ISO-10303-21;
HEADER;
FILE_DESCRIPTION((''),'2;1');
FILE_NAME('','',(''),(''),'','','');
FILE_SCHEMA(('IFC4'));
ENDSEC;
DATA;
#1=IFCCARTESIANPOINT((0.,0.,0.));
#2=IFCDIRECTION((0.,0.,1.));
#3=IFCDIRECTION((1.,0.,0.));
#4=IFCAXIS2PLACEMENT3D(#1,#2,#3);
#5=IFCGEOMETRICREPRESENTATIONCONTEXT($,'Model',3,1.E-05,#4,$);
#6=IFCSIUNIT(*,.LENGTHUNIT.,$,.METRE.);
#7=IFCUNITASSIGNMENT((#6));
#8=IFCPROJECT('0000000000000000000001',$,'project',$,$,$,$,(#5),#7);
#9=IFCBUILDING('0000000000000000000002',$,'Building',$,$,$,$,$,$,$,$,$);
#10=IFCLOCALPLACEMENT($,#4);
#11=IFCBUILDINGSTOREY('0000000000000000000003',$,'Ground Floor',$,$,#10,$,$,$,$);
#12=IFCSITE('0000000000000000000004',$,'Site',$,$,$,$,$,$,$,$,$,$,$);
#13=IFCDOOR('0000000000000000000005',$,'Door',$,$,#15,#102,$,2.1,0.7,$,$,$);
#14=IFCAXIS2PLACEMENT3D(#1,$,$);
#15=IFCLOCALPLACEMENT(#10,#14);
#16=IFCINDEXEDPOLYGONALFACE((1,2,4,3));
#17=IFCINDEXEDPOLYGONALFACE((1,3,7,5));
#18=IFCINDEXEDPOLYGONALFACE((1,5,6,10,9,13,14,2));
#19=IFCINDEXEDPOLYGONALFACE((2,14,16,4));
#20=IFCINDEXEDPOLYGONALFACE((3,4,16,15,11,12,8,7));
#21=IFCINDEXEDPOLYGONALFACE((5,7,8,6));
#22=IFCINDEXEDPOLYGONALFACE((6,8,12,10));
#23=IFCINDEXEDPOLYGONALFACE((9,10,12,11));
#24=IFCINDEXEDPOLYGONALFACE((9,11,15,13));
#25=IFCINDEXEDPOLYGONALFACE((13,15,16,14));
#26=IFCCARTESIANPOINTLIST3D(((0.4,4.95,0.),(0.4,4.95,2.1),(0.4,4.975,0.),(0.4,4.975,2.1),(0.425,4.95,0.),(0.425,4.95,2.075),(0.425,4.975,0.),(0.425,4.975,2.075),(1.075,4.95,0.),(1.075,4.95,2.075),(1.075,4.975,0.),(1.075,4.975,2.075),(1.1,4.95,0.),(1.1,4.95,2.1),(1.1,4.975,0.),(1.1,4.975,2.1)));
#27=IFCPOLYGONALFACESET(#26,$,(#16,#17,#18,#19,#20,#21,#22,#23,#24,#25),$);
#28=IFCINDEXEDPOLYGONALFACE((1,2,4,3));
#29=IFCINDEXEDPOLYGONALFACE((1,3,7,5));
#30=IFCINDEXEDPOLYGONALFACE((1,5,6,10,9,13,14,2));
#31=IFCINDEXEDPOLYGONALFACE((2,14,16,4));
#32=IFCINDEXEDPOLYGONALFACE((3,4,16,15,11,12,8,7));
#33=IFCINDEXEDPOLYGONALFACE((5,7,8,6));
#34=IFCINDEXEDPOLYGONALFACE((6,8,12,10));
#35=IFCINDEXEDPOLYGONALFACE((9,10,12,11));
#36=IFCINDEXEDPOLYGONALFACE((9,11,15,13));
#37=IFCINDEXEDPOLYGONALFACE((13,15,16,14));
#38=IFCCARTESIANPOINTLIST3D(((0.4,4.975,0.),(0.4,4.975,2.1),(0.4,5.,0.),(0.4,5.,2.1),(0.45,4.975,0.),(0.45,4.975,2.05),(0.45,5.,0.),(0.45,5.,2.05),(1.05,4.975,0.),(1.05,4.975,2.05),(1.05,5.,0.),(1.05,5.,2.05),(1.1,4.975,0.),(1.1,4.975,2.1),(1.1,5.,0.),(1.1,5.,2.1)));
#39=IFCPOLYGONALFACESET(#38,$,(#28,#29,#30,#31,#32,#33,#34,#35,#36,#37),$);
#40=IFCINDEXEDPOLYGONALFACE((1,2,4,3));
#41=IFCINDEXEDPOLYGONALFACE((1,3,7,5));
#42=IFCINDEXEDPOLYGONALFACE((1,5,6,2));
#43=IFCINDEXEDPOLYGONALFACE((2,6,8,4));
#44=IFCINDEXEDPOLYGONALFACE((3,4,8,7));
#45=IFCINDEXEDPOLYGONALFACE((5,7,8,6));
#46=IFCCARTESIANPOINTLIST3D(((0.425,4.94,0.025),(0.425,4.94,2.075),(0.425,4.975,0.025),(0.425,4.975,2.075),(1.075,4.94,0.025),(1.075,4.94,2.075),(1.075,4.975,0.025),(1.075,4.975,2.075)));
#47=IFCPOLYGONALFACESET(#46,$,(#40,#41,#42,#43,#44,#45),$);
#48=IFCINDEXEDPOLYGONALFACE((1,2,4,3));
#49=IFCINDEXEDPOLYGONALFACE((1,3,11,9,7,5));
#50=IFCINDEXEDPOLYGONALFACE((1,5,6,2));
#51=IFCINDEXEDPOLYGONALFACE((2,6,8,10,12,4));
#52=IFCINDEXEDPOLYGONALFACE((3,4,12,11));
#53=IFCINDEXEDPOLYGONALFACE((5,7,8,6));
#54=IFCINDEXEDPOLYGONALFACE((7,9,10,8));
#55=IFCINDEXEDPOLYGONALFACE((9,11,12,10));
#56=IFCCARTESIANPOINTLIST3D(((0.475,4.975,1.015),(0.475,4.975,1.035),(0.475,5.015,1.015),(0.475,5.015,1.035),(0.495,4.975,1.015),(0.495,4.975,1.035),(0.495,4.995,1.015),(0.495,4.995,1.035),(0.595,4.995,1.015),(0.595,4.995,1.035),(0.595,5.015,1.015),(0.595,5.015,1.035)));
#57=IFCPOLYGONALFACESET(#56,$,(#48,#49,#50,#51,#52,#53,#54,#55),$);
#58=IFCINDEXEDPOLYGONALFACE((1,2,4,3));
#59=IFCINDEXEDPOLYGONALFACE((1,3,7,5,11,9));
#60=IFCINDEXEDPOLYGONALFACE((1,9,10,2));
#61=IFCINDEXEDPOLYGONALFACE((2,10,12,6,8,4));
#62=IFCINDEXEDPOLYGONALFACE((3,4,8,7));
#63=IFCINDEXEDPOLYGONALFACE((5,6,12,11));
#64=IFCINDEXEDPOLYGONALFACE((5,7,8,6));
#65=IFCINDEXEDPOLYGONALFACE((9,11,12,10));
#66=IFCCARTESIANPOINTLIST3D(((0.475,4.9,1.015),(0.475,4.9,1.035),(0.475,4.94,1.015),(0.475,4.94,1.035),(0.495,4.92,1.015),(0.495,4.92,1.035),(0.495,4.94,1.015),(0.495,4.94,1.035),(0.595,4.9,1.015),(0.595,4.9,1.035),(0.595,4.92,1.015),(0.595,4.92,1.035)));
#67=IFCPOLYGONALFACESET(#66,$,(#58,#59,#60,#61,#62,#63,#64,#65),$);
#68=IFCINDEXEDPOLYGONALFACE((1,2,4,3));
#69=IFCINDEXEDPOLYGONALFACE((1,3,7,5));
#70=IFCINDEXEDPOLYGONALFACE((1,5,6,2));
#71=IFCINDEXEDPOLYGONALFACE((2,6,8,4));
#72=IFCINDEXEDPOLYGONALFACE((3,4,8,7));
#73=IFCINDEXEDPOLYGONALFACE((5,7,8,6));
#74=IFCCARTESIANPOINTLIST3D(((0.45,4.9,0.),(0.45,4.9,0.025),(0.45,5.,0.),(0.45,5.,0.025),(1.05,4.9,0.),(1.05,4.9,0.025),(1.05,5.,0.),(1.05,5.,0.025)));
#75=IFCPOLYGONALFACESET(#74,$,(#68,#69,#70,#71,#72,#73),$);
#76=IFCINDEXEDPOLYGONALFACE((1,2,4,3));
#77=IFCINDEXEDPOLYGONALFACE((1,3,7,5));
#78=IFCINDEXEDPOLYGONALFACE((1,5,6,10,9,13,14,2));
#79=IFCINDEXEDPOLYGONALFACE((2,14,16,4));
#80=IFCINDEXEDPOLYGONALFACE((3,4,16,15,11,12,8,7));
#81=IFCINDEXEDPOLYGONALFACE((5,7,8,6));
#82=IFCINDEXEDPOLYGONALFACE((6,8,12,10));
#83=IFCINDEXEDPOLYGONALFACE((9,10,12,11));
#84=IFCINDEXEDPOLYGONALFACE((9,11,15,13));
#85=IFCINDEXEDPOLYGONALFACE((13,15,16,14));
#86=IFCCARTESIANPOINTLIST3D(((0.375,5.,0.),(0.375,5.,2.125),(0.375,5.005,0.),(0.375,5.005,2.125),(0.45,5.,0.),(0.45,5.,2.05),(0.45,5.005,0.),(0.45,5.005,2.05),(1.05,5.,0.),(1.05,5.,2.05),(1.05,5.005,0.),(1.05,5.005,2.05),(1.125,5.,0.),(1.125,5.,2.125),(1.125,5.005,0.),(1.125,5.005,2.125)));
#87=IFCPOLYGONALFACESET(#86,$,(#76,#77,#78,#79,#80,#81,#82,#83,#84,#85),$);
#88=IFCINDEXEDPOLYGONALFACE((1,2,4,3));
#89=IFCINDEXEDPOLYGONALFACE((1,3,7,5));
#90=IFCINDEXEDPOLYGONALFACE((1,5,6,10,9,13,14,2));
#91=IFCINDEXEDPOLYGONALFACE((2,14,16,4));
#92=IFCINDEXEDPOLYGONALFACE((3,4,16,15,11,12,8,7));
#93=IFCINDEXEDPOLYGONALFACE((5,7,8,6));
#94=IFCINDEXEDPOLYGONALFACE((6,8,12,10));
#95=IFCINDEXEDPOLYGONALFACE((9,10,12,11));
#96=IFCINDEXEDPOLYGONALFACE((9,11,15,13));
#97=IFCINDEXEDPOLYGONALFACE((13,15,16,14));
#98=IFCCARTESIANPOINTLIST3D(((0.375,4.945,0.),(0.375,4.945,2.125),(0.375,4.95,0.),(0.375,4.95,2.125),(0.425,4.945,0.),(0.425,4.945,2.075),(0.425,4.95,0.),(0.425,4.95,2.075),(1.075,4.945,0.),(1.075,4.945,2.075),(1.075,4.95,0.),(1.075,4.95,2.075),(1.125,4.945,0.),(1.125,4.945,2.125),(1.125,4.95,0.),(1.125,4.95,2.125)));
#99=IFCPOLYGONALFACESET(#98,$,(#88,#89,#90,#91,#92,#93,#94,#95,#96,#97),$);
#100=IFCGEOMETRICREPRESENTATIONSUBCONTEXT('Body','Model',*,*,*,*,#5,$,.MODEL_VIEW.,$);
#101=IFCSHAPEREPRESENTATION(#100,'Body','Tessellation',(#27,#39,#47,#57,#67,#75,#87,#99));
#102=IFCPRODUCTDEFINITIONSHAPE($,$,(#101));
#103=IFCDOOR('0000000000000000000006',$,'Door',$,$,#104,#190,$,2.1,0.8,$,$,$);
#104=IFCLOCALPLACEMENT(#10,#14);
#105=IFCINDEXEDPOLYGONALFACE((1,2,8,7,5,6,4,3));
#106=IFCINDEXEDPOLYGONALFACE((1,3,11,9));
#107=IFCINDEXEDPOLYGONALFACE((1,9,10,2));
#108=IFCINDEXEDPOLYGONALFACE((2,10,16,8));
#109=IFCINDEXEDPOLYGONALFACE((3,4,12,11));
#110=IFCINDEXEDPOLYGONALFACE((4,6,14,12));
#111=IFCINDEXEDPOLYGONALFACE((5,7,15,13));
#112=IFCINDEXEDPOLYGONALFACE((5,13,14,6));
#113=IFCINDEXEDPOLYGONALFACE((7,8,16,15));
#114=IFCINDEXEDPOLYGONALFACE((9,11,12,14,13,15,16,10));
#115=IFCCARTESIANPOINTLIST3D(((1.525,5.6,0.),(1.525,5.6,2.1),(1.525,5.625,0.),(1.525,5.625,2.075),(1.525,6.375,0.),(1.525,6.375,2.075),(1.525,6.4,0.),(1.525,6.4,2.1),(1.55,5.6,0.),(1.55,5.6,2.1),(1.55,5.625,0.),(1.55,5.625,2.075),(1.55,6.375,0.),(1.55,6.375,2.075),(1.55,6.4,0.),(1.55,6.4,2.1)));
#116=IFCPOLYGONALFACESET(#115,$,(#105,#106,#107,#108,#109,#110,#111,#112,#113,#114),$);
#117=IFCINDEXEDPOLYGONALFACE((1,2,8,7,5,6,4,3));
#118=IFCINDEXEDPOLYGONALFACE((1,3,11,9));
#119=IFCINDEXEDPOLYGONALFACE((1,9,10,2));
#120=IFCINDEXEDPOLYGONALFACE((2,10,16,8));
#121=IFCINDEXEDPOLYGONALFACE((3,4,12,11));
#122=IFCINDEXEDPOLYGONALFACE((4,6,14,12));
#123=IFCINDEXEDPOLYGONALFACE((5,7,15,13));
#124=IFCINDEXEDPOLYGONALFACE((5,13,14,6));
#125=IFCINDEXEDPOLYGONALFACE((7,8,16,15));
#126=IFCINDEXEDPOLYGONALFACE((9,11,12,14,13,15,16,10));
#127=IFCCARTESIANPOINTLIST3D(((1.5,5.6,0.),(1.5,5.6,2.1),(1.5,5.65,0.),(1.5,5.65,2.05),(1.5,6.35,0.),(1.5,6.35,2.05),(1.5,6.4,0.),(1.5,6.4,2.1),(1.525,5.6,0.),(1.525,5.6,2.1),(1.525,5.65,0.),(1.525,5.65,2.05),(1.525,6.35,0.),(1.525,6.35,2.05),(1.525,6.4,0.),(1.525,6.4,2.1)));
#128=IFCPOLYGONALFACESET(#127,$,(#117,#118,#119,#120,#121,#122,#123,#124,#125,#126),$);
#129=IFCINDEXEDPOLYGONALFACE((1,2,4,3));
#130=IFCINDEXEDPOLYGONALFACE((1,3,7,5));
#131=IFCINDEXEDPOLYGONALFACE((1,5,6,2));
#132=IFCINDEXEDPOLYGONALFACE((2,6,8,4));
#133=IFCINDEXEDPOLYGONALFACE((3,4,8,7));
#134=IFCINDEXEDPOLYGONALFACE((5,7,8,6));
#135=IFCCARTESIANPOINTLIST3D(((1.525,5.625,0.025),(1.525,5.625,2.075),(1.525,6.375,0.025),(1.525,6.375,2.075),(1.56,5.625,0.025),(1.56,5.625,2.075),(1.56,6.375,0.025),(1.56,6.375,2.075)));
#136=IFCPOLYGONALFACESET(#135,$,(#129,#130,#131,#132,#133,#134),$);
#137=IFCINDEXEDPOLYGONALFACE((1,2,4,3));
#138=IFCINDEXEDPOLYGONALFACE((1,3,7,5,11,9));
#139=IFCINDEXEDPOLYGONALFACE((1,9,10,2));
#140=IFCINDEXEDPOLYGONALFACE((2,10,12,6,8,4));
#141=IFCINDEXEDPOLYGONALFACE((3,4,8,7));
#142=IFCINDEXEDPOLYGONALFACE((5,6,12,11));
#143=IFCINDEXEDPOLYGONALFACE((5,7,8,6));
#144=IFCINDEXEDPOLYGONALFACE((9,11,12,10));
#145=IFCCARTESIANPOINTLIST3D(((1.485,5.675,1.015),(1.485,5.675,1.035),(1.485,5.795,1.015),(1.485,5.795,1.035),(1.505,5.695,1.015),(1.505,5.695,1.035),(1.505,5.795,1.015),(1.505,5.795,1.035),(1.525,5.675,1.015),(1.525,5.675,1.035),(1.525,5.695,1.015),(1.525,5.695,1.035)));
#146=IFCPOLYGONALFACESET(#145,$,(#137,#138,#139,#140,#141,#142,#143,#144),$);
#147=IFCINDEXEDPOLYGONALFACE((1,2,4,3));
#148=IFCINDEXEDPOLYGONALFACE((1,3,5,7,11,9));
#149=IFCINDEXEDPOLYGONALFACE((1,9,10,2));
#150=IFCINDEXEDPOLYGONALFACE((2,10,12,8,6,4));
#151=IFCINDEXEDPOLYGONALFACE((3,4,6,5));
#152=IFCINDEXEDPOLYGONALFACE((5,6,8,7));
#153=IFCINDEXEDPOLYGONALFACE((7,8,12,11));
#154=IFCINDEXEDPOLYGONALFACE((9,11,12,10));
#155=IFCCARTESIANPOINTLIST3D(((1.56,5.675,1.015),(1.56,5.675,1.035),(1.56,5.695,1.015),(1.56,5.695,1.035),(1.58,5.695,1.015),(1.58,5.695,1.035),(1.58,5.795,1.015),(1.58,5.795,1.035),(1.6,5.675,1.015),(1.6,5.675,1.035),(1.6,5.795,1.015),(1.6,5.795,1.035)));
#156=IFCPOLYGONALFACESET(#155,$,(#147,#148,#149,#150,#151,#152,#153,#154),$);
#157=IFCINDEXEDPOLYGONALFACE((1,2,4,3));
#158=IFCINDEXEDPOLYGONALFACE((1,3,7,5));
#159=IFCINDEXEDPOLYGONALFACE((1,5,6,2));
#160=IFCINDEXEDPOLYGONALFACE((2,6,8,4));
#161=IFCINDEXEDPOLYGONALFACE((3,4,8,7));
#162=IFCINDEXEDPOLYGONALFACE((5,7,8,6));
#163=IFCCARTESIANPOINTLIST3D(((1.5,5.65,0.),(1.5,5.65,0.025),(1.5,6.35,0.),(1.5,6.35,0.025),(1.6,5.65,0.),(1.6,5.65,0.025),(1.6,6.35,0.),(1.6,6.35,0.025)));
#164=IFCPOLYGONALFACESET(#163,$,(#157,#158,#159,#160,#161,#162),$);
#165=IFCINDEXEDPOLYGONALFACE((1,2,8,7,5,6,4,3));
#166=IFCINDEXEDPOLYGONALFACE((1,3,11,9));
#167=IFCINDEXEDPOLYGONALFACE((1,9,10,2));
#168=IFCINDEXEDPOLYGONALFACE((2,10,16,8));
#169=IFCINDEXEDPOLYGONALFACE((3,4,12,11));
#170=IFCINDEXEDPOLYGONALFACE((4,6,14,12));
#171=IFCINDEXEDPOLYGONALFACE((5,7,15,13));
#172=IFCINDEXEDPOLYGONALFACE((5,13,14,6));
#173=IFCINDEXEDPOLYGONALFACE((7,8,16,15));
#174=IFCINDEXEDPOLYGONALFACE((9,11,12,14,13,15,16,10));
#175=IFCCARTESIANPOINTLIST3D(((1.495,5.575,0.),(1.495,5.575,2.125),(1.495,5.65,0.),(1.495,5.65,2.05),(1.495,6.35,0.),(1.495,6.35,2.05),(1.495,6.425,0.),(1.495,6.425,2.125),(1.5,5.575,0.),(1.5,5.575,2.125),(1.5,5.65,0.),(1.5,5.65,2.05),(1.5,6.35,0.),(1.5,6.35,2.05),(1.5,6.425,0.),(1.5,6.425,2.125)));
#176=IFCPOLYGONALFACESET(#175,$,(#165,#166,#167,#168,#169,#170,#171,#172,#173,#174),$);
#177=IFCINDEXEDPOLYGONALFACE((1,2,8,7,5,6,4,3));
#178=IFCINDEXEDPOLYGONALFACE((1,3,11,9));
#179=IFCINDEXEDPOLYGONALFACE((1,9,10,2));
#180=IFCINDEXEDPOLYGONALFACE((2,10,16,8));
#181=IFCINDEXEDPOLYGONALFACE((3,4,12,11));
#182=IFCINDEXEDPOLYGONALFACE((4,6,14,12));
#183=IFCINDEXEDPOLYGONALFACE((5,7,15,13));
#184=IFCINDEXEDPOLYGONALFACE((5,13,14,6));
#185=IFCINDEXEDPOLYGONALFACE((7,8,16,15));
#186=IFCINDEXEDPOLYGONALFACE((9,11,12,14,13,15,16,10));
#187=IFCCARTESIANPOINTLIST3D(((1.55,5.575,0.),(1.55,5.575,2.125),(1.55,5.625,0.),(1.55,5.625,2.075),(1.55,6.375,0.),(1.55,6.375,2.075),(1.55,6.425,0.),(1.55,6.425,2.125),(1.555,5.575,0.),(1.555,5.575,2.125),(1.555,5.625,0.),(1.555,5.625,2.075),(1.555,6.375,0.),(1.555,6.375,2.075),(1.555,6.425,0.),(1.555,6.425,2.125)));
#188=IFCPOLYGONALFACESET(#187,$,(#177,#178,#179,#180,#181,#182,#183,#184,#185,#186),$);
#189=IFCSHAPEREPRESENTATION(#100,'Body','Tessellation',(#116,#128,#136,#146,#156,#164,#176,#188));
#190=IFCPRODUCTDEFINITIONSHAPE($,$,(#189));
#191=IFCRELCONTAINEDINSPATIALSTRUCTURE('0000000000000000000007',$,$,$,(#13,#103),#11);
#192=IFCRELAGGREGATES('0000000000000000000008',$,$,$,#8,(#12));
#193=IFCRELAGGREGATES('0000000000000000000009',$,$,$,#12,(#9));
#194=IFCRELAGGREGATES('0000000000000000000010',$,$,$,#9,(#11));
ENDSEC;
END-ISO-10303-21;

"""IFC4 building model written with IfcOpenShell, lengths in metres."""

from ifc_helpers import new_model, si_unit, frame, origin_with_axes, place, context, subcontext, project, spatial, line, indexed_curve, outline, extrude, element, save


model = new_model("IFC4")

# Units and contexts
model_context = context("Model", 3, precision=1e-05, world=origin_with_axes())
body_context = subcontext(model_context, "Body", "Model", "MODEL_VIEW")
ifc_project = project(units=[si_unit("LENGTHUNIT", "METRE")], contexts=[model_context])

# Site, building, storey
site = spatial("IfcSite", under=ifc_project, Name="Site")
building = spatial("IfcBuilding", under=site, Name="Building")
storey_placement = place(None, origin_with_axes())
storey = spatial("IfcBuildingStorey", under=building, at=storey_placement, Name="Ground Floor")

# Doors
door_1_placement = place(storey_placement, frame((1.1, 5.0, 0.0), z_axis=(0.0, 0.0, 1.0), x_axis=(-1.0, 0.0, 0.0)))
element("IfcDoor", 1, at=door_1_placement, inside=storey, Name="Door", OverallHeight=2.1, OverallWidth=0.7, context=body_context, shape_type="SweptSolid", body=[
    extrude(outline(indexed_curve([(0.0, 0.0), (0.0, 2.1), (0.7, 2.1), (0.7, 0.0), (0.675, 0.0), (0.675, 2.075), (0.025, 2.075), (0.025, 0.0)], segments=[line(1, 2, 3, 4, 5, 6, 7, 8, 1)])), frame((0.0, 0.025, 0.0), z_axis=(0.0, -1.0, 0.0), x_axis=(1.0, 0.0, 0.0)), (0.0, 0.0, -1.0), 0.025),
    extrude(outline(indexed_curve([(0.0, 0.0), (0.0, 2.1), (0.7, 2.1), (0.7, 0.0), (0.65, 0.0), (0.65, 2.05), (0.05, 2.05), (0.05, 0.0)], segments=[line(1, 2, 3, 4, 5, 6, 7, 8, 1)])), frame((0.0, 0.0, 0.0), z_axis=(0.0, -1.0, 0.0), x_axis=(1.0, 0.0, 0.0)), (0.0, 0.0, -1.0), 0.025),
    extrude(outline(indexed_curve([(0.0, 0.0), (0.65, 0.0), (0.65, 0.035), (0.0, 0.035)], segments=[line(1, 2, 3, 4, 1)])), frame((0.025, 0.025, 0.025), z_axis=(0.0, 0.0, 1.0), x_axis=(1.0, 0.0, 0.0)), (0.0, 0.0, 1.0), 2.05),
    extrude(outline(indexed_curve([(0.0, 0.0), (0.0, -0.04), (-0.12, -0.04), (-0.12, -0.02), (-0.02, -0.02), (-0.02, 0.0)], segments=[line(1, 2, 3, 4, 5, 6, 1)])), frame((0.625, 0.025, 1.015), z_axis=(0.0, 0.0, 1.0), x_axis=(1.0, 0.0, 0.0)), (0.0, 0.0, 1.0), 0.02),
    extrude(outline(indexed_curve([(0.0, 0.0), (0.0, 0.04), (-0.12, 0.04), (-0.12, 0.02), (-0.02, 0.02), (-0.02, 0.0)], segments=[line(1, 2, 3, 4, 5, 6, 1)])), frame((0.625, 0.06, 1.015), z_axis=(0.0, 0.0, 1.0), x_axis=(1.0, 0.0, 0.0)), (0.0, 0.0, 1.0), 0.02),
    extrude(outline(indexed_curve([(0.0, 0.0), (0.6, 0.0), (0.6, 0.1), (0.0, 0.1)], segments=[line(1, 2, 3, 4, 1)])), frame((0.05, 0.0, 0.0), z_axis=(0.0, 0.0, 1.0), x_axis=(1.0, 0.0, 0.0)), (0.0, 0.0, 1.0), 0.025),
    extrude(outline(indexed_curve([(0.0, 0.0), (0.0, 2.125), (0.75, 2.125), (0.75, 0.0), (0.675, 0.0), (0.675, 2.05), (0.075, 2.05), (0.075, 0.0)], segments=[line(1, 2, 3, 4, 5, 6, 7, 8, 1)])), frame((-0.025, -0.005, 0.0), z_axis=(0.0, -1.0, 0.0), x_axis=(1.0, 0.0, 0.0)), (0.0, 0.0, -1.0), 0.005),
    extrude(outline(indexed_curve([(0.0, 0.0), (0.0, 2.125), (0.75, 2.125), (0.75, 0.0), (0.7, 0.0), (0.7, 2.075), (0.05, 2.075), (0.05, 0.0)], segments=[line(1, 2, 3, 4, 5, 6, 7, 8, 1)])), frame((-0.025, 0.05, 0.0), z_axis=(0.0, -1.0, 0.0), x_axis=(1.0, 0.0, 0.0)), (0.0, 0.0, -1.0), 0.005),
])
door_2_placement = place(storey_placement, frame((1.5, 6.4, 0.0), z_axis=(0.0, 0.0, 1.0), x_axis=(0.0, -1.0, 0.0)))
element("IfcDoor", 2, at=door_2_placement, inside=storey, Name="Door", OverallHeight=2.1, OverallWidth=0.8, context=body_context, shape_type="SweptSolid", body=[
    extrude(outline(indexed_curve([(0.0, 0.0), (0.0, 2.1), (0.8, 2.1), (0.8, 0.0), (0.775, 0.0), (0.775, 2.075), (0.025, 2.075), (0.025, 0.0)], segments=[line(1, 2, 3, 4, 5, 6, 7, 8, 1)])), frame((0.0, 0.025, 0.0), z_axis=(0.0, -1.0, 0.0), x_axis=(1.0, 0.0, 0.0)), (0.0, 0.0, -1.0), 0.025),
    extrude(outline(indexed_curve([(0.0, 0.0), (0.0, 2.1), (0.8, 2.1), (0.8, 0.0), (0.75, 0.0), (0.75, 2.05), (0.05, 2.05), (0.05, 0.0)], segments=[line(1, 2, 3, 4, 5, 6, 7, 8, 1)])), frame((0.0, 0.0, 0.0), z_axis=(0.0, -1.0, 0.0), x_axis=(1.0, 0.0, 0.0)), (0.0, 0.0, -1.0), 0.025),
    extrude(outline(indexed_curve([(0.0, 0.0), (0.75, 0.0), (0.75, 0.035), (0.0, 0.035)], segments=[line(1, 2, 3, 4, 1)])), frame((0.025, 0.025, 0.025), z_axis=(0.0, 0.0, 1.0), x_axis=(1.0, 0.0, 0.0)), (0.0, 0.0, 1.0), 2.05),
    extrude(outline(indexed_curve([(0.0, 0.0), (0.0, -0.04), (-0.12, -0.04), (-0.12, -0.02), (-0.02, -0.02), (-0.02, 0.0)], segments=[line(1, 2, 3, 4, 5, 6, 1)])), frame((0.725, 0.025, 1.015), z_axis=(0.0, 0.0, 1.0), x_axis=(1.0, 0.0, 0.0)), (0.0, 0.0, 1.0), 0.02),
    extrude(outline(indexed_curve([(0.0, 0.0), (0.0, 0.04), (-0.12, 0.04), (-0.12, 0.02), (-0.02, 0.02), (-0.02, 0.0)], segments=[line(1, 2, 3, 4, 5, 6, 1)])), frame((0.725, 0.06, 1.015), z_axis=(0.0, 0.0, 1.0), x_axis=(1.0, 0.0, 0.0)), (0.0, 0.0, 1.0), 0.02),
    extrude(outline(indexed_curve([(0.0, 0.0), (0.7, 0.0), (0.7, 0.1), (0.0, 0.1)], segments=[line(1, 2, 3, 4, 1)])), frame((0.05, 0.0, 0.0), z_axis=(0.0, 0.0, 1.0), x_axis=(1.0, 0.0, 0.0)), (0.0, 0.0, 1.0), 0.025),
    extrude(outline(indexed_curve([(0.0, 0.0), (0.0, 2.125), (0.85, 2.125), (0.85, 0.0), (0.775, 0.0), (0.775, 2.05), (0.075, 2.05), (0.075, 0.0)], segments=[line(1, 2, 3, 4, 5, 6, 7, 8, 1)])), frame((-0.025, -0.005, 0.0), z_axis=(0.0, -1.0, 0.0), x_axis=(1.0, 0.0, 0.0)), (0.0, 0.0, -1.0), 0.005),
    extrude(outline(indexed_curve([(0.0, 0.0), (0.0, 2.125), (0.85, 2.125), (0.85, 0.0), (0.8, 0.0), (0.8, 2.075), (0.05, 2.075), (0.05, 0.0)], segments=[line(1, 2, 3, 4, 5, 6, 7, 8, 1)])), frame((-0.025, 0.05, 0.0), z_axis=(0.0, -1.0, 0.0), x_axis=(1.0, 0.0, 0.0)), (0.0, 0.0, -1.0), 0.005),
])

save(model, "model.ifc")
